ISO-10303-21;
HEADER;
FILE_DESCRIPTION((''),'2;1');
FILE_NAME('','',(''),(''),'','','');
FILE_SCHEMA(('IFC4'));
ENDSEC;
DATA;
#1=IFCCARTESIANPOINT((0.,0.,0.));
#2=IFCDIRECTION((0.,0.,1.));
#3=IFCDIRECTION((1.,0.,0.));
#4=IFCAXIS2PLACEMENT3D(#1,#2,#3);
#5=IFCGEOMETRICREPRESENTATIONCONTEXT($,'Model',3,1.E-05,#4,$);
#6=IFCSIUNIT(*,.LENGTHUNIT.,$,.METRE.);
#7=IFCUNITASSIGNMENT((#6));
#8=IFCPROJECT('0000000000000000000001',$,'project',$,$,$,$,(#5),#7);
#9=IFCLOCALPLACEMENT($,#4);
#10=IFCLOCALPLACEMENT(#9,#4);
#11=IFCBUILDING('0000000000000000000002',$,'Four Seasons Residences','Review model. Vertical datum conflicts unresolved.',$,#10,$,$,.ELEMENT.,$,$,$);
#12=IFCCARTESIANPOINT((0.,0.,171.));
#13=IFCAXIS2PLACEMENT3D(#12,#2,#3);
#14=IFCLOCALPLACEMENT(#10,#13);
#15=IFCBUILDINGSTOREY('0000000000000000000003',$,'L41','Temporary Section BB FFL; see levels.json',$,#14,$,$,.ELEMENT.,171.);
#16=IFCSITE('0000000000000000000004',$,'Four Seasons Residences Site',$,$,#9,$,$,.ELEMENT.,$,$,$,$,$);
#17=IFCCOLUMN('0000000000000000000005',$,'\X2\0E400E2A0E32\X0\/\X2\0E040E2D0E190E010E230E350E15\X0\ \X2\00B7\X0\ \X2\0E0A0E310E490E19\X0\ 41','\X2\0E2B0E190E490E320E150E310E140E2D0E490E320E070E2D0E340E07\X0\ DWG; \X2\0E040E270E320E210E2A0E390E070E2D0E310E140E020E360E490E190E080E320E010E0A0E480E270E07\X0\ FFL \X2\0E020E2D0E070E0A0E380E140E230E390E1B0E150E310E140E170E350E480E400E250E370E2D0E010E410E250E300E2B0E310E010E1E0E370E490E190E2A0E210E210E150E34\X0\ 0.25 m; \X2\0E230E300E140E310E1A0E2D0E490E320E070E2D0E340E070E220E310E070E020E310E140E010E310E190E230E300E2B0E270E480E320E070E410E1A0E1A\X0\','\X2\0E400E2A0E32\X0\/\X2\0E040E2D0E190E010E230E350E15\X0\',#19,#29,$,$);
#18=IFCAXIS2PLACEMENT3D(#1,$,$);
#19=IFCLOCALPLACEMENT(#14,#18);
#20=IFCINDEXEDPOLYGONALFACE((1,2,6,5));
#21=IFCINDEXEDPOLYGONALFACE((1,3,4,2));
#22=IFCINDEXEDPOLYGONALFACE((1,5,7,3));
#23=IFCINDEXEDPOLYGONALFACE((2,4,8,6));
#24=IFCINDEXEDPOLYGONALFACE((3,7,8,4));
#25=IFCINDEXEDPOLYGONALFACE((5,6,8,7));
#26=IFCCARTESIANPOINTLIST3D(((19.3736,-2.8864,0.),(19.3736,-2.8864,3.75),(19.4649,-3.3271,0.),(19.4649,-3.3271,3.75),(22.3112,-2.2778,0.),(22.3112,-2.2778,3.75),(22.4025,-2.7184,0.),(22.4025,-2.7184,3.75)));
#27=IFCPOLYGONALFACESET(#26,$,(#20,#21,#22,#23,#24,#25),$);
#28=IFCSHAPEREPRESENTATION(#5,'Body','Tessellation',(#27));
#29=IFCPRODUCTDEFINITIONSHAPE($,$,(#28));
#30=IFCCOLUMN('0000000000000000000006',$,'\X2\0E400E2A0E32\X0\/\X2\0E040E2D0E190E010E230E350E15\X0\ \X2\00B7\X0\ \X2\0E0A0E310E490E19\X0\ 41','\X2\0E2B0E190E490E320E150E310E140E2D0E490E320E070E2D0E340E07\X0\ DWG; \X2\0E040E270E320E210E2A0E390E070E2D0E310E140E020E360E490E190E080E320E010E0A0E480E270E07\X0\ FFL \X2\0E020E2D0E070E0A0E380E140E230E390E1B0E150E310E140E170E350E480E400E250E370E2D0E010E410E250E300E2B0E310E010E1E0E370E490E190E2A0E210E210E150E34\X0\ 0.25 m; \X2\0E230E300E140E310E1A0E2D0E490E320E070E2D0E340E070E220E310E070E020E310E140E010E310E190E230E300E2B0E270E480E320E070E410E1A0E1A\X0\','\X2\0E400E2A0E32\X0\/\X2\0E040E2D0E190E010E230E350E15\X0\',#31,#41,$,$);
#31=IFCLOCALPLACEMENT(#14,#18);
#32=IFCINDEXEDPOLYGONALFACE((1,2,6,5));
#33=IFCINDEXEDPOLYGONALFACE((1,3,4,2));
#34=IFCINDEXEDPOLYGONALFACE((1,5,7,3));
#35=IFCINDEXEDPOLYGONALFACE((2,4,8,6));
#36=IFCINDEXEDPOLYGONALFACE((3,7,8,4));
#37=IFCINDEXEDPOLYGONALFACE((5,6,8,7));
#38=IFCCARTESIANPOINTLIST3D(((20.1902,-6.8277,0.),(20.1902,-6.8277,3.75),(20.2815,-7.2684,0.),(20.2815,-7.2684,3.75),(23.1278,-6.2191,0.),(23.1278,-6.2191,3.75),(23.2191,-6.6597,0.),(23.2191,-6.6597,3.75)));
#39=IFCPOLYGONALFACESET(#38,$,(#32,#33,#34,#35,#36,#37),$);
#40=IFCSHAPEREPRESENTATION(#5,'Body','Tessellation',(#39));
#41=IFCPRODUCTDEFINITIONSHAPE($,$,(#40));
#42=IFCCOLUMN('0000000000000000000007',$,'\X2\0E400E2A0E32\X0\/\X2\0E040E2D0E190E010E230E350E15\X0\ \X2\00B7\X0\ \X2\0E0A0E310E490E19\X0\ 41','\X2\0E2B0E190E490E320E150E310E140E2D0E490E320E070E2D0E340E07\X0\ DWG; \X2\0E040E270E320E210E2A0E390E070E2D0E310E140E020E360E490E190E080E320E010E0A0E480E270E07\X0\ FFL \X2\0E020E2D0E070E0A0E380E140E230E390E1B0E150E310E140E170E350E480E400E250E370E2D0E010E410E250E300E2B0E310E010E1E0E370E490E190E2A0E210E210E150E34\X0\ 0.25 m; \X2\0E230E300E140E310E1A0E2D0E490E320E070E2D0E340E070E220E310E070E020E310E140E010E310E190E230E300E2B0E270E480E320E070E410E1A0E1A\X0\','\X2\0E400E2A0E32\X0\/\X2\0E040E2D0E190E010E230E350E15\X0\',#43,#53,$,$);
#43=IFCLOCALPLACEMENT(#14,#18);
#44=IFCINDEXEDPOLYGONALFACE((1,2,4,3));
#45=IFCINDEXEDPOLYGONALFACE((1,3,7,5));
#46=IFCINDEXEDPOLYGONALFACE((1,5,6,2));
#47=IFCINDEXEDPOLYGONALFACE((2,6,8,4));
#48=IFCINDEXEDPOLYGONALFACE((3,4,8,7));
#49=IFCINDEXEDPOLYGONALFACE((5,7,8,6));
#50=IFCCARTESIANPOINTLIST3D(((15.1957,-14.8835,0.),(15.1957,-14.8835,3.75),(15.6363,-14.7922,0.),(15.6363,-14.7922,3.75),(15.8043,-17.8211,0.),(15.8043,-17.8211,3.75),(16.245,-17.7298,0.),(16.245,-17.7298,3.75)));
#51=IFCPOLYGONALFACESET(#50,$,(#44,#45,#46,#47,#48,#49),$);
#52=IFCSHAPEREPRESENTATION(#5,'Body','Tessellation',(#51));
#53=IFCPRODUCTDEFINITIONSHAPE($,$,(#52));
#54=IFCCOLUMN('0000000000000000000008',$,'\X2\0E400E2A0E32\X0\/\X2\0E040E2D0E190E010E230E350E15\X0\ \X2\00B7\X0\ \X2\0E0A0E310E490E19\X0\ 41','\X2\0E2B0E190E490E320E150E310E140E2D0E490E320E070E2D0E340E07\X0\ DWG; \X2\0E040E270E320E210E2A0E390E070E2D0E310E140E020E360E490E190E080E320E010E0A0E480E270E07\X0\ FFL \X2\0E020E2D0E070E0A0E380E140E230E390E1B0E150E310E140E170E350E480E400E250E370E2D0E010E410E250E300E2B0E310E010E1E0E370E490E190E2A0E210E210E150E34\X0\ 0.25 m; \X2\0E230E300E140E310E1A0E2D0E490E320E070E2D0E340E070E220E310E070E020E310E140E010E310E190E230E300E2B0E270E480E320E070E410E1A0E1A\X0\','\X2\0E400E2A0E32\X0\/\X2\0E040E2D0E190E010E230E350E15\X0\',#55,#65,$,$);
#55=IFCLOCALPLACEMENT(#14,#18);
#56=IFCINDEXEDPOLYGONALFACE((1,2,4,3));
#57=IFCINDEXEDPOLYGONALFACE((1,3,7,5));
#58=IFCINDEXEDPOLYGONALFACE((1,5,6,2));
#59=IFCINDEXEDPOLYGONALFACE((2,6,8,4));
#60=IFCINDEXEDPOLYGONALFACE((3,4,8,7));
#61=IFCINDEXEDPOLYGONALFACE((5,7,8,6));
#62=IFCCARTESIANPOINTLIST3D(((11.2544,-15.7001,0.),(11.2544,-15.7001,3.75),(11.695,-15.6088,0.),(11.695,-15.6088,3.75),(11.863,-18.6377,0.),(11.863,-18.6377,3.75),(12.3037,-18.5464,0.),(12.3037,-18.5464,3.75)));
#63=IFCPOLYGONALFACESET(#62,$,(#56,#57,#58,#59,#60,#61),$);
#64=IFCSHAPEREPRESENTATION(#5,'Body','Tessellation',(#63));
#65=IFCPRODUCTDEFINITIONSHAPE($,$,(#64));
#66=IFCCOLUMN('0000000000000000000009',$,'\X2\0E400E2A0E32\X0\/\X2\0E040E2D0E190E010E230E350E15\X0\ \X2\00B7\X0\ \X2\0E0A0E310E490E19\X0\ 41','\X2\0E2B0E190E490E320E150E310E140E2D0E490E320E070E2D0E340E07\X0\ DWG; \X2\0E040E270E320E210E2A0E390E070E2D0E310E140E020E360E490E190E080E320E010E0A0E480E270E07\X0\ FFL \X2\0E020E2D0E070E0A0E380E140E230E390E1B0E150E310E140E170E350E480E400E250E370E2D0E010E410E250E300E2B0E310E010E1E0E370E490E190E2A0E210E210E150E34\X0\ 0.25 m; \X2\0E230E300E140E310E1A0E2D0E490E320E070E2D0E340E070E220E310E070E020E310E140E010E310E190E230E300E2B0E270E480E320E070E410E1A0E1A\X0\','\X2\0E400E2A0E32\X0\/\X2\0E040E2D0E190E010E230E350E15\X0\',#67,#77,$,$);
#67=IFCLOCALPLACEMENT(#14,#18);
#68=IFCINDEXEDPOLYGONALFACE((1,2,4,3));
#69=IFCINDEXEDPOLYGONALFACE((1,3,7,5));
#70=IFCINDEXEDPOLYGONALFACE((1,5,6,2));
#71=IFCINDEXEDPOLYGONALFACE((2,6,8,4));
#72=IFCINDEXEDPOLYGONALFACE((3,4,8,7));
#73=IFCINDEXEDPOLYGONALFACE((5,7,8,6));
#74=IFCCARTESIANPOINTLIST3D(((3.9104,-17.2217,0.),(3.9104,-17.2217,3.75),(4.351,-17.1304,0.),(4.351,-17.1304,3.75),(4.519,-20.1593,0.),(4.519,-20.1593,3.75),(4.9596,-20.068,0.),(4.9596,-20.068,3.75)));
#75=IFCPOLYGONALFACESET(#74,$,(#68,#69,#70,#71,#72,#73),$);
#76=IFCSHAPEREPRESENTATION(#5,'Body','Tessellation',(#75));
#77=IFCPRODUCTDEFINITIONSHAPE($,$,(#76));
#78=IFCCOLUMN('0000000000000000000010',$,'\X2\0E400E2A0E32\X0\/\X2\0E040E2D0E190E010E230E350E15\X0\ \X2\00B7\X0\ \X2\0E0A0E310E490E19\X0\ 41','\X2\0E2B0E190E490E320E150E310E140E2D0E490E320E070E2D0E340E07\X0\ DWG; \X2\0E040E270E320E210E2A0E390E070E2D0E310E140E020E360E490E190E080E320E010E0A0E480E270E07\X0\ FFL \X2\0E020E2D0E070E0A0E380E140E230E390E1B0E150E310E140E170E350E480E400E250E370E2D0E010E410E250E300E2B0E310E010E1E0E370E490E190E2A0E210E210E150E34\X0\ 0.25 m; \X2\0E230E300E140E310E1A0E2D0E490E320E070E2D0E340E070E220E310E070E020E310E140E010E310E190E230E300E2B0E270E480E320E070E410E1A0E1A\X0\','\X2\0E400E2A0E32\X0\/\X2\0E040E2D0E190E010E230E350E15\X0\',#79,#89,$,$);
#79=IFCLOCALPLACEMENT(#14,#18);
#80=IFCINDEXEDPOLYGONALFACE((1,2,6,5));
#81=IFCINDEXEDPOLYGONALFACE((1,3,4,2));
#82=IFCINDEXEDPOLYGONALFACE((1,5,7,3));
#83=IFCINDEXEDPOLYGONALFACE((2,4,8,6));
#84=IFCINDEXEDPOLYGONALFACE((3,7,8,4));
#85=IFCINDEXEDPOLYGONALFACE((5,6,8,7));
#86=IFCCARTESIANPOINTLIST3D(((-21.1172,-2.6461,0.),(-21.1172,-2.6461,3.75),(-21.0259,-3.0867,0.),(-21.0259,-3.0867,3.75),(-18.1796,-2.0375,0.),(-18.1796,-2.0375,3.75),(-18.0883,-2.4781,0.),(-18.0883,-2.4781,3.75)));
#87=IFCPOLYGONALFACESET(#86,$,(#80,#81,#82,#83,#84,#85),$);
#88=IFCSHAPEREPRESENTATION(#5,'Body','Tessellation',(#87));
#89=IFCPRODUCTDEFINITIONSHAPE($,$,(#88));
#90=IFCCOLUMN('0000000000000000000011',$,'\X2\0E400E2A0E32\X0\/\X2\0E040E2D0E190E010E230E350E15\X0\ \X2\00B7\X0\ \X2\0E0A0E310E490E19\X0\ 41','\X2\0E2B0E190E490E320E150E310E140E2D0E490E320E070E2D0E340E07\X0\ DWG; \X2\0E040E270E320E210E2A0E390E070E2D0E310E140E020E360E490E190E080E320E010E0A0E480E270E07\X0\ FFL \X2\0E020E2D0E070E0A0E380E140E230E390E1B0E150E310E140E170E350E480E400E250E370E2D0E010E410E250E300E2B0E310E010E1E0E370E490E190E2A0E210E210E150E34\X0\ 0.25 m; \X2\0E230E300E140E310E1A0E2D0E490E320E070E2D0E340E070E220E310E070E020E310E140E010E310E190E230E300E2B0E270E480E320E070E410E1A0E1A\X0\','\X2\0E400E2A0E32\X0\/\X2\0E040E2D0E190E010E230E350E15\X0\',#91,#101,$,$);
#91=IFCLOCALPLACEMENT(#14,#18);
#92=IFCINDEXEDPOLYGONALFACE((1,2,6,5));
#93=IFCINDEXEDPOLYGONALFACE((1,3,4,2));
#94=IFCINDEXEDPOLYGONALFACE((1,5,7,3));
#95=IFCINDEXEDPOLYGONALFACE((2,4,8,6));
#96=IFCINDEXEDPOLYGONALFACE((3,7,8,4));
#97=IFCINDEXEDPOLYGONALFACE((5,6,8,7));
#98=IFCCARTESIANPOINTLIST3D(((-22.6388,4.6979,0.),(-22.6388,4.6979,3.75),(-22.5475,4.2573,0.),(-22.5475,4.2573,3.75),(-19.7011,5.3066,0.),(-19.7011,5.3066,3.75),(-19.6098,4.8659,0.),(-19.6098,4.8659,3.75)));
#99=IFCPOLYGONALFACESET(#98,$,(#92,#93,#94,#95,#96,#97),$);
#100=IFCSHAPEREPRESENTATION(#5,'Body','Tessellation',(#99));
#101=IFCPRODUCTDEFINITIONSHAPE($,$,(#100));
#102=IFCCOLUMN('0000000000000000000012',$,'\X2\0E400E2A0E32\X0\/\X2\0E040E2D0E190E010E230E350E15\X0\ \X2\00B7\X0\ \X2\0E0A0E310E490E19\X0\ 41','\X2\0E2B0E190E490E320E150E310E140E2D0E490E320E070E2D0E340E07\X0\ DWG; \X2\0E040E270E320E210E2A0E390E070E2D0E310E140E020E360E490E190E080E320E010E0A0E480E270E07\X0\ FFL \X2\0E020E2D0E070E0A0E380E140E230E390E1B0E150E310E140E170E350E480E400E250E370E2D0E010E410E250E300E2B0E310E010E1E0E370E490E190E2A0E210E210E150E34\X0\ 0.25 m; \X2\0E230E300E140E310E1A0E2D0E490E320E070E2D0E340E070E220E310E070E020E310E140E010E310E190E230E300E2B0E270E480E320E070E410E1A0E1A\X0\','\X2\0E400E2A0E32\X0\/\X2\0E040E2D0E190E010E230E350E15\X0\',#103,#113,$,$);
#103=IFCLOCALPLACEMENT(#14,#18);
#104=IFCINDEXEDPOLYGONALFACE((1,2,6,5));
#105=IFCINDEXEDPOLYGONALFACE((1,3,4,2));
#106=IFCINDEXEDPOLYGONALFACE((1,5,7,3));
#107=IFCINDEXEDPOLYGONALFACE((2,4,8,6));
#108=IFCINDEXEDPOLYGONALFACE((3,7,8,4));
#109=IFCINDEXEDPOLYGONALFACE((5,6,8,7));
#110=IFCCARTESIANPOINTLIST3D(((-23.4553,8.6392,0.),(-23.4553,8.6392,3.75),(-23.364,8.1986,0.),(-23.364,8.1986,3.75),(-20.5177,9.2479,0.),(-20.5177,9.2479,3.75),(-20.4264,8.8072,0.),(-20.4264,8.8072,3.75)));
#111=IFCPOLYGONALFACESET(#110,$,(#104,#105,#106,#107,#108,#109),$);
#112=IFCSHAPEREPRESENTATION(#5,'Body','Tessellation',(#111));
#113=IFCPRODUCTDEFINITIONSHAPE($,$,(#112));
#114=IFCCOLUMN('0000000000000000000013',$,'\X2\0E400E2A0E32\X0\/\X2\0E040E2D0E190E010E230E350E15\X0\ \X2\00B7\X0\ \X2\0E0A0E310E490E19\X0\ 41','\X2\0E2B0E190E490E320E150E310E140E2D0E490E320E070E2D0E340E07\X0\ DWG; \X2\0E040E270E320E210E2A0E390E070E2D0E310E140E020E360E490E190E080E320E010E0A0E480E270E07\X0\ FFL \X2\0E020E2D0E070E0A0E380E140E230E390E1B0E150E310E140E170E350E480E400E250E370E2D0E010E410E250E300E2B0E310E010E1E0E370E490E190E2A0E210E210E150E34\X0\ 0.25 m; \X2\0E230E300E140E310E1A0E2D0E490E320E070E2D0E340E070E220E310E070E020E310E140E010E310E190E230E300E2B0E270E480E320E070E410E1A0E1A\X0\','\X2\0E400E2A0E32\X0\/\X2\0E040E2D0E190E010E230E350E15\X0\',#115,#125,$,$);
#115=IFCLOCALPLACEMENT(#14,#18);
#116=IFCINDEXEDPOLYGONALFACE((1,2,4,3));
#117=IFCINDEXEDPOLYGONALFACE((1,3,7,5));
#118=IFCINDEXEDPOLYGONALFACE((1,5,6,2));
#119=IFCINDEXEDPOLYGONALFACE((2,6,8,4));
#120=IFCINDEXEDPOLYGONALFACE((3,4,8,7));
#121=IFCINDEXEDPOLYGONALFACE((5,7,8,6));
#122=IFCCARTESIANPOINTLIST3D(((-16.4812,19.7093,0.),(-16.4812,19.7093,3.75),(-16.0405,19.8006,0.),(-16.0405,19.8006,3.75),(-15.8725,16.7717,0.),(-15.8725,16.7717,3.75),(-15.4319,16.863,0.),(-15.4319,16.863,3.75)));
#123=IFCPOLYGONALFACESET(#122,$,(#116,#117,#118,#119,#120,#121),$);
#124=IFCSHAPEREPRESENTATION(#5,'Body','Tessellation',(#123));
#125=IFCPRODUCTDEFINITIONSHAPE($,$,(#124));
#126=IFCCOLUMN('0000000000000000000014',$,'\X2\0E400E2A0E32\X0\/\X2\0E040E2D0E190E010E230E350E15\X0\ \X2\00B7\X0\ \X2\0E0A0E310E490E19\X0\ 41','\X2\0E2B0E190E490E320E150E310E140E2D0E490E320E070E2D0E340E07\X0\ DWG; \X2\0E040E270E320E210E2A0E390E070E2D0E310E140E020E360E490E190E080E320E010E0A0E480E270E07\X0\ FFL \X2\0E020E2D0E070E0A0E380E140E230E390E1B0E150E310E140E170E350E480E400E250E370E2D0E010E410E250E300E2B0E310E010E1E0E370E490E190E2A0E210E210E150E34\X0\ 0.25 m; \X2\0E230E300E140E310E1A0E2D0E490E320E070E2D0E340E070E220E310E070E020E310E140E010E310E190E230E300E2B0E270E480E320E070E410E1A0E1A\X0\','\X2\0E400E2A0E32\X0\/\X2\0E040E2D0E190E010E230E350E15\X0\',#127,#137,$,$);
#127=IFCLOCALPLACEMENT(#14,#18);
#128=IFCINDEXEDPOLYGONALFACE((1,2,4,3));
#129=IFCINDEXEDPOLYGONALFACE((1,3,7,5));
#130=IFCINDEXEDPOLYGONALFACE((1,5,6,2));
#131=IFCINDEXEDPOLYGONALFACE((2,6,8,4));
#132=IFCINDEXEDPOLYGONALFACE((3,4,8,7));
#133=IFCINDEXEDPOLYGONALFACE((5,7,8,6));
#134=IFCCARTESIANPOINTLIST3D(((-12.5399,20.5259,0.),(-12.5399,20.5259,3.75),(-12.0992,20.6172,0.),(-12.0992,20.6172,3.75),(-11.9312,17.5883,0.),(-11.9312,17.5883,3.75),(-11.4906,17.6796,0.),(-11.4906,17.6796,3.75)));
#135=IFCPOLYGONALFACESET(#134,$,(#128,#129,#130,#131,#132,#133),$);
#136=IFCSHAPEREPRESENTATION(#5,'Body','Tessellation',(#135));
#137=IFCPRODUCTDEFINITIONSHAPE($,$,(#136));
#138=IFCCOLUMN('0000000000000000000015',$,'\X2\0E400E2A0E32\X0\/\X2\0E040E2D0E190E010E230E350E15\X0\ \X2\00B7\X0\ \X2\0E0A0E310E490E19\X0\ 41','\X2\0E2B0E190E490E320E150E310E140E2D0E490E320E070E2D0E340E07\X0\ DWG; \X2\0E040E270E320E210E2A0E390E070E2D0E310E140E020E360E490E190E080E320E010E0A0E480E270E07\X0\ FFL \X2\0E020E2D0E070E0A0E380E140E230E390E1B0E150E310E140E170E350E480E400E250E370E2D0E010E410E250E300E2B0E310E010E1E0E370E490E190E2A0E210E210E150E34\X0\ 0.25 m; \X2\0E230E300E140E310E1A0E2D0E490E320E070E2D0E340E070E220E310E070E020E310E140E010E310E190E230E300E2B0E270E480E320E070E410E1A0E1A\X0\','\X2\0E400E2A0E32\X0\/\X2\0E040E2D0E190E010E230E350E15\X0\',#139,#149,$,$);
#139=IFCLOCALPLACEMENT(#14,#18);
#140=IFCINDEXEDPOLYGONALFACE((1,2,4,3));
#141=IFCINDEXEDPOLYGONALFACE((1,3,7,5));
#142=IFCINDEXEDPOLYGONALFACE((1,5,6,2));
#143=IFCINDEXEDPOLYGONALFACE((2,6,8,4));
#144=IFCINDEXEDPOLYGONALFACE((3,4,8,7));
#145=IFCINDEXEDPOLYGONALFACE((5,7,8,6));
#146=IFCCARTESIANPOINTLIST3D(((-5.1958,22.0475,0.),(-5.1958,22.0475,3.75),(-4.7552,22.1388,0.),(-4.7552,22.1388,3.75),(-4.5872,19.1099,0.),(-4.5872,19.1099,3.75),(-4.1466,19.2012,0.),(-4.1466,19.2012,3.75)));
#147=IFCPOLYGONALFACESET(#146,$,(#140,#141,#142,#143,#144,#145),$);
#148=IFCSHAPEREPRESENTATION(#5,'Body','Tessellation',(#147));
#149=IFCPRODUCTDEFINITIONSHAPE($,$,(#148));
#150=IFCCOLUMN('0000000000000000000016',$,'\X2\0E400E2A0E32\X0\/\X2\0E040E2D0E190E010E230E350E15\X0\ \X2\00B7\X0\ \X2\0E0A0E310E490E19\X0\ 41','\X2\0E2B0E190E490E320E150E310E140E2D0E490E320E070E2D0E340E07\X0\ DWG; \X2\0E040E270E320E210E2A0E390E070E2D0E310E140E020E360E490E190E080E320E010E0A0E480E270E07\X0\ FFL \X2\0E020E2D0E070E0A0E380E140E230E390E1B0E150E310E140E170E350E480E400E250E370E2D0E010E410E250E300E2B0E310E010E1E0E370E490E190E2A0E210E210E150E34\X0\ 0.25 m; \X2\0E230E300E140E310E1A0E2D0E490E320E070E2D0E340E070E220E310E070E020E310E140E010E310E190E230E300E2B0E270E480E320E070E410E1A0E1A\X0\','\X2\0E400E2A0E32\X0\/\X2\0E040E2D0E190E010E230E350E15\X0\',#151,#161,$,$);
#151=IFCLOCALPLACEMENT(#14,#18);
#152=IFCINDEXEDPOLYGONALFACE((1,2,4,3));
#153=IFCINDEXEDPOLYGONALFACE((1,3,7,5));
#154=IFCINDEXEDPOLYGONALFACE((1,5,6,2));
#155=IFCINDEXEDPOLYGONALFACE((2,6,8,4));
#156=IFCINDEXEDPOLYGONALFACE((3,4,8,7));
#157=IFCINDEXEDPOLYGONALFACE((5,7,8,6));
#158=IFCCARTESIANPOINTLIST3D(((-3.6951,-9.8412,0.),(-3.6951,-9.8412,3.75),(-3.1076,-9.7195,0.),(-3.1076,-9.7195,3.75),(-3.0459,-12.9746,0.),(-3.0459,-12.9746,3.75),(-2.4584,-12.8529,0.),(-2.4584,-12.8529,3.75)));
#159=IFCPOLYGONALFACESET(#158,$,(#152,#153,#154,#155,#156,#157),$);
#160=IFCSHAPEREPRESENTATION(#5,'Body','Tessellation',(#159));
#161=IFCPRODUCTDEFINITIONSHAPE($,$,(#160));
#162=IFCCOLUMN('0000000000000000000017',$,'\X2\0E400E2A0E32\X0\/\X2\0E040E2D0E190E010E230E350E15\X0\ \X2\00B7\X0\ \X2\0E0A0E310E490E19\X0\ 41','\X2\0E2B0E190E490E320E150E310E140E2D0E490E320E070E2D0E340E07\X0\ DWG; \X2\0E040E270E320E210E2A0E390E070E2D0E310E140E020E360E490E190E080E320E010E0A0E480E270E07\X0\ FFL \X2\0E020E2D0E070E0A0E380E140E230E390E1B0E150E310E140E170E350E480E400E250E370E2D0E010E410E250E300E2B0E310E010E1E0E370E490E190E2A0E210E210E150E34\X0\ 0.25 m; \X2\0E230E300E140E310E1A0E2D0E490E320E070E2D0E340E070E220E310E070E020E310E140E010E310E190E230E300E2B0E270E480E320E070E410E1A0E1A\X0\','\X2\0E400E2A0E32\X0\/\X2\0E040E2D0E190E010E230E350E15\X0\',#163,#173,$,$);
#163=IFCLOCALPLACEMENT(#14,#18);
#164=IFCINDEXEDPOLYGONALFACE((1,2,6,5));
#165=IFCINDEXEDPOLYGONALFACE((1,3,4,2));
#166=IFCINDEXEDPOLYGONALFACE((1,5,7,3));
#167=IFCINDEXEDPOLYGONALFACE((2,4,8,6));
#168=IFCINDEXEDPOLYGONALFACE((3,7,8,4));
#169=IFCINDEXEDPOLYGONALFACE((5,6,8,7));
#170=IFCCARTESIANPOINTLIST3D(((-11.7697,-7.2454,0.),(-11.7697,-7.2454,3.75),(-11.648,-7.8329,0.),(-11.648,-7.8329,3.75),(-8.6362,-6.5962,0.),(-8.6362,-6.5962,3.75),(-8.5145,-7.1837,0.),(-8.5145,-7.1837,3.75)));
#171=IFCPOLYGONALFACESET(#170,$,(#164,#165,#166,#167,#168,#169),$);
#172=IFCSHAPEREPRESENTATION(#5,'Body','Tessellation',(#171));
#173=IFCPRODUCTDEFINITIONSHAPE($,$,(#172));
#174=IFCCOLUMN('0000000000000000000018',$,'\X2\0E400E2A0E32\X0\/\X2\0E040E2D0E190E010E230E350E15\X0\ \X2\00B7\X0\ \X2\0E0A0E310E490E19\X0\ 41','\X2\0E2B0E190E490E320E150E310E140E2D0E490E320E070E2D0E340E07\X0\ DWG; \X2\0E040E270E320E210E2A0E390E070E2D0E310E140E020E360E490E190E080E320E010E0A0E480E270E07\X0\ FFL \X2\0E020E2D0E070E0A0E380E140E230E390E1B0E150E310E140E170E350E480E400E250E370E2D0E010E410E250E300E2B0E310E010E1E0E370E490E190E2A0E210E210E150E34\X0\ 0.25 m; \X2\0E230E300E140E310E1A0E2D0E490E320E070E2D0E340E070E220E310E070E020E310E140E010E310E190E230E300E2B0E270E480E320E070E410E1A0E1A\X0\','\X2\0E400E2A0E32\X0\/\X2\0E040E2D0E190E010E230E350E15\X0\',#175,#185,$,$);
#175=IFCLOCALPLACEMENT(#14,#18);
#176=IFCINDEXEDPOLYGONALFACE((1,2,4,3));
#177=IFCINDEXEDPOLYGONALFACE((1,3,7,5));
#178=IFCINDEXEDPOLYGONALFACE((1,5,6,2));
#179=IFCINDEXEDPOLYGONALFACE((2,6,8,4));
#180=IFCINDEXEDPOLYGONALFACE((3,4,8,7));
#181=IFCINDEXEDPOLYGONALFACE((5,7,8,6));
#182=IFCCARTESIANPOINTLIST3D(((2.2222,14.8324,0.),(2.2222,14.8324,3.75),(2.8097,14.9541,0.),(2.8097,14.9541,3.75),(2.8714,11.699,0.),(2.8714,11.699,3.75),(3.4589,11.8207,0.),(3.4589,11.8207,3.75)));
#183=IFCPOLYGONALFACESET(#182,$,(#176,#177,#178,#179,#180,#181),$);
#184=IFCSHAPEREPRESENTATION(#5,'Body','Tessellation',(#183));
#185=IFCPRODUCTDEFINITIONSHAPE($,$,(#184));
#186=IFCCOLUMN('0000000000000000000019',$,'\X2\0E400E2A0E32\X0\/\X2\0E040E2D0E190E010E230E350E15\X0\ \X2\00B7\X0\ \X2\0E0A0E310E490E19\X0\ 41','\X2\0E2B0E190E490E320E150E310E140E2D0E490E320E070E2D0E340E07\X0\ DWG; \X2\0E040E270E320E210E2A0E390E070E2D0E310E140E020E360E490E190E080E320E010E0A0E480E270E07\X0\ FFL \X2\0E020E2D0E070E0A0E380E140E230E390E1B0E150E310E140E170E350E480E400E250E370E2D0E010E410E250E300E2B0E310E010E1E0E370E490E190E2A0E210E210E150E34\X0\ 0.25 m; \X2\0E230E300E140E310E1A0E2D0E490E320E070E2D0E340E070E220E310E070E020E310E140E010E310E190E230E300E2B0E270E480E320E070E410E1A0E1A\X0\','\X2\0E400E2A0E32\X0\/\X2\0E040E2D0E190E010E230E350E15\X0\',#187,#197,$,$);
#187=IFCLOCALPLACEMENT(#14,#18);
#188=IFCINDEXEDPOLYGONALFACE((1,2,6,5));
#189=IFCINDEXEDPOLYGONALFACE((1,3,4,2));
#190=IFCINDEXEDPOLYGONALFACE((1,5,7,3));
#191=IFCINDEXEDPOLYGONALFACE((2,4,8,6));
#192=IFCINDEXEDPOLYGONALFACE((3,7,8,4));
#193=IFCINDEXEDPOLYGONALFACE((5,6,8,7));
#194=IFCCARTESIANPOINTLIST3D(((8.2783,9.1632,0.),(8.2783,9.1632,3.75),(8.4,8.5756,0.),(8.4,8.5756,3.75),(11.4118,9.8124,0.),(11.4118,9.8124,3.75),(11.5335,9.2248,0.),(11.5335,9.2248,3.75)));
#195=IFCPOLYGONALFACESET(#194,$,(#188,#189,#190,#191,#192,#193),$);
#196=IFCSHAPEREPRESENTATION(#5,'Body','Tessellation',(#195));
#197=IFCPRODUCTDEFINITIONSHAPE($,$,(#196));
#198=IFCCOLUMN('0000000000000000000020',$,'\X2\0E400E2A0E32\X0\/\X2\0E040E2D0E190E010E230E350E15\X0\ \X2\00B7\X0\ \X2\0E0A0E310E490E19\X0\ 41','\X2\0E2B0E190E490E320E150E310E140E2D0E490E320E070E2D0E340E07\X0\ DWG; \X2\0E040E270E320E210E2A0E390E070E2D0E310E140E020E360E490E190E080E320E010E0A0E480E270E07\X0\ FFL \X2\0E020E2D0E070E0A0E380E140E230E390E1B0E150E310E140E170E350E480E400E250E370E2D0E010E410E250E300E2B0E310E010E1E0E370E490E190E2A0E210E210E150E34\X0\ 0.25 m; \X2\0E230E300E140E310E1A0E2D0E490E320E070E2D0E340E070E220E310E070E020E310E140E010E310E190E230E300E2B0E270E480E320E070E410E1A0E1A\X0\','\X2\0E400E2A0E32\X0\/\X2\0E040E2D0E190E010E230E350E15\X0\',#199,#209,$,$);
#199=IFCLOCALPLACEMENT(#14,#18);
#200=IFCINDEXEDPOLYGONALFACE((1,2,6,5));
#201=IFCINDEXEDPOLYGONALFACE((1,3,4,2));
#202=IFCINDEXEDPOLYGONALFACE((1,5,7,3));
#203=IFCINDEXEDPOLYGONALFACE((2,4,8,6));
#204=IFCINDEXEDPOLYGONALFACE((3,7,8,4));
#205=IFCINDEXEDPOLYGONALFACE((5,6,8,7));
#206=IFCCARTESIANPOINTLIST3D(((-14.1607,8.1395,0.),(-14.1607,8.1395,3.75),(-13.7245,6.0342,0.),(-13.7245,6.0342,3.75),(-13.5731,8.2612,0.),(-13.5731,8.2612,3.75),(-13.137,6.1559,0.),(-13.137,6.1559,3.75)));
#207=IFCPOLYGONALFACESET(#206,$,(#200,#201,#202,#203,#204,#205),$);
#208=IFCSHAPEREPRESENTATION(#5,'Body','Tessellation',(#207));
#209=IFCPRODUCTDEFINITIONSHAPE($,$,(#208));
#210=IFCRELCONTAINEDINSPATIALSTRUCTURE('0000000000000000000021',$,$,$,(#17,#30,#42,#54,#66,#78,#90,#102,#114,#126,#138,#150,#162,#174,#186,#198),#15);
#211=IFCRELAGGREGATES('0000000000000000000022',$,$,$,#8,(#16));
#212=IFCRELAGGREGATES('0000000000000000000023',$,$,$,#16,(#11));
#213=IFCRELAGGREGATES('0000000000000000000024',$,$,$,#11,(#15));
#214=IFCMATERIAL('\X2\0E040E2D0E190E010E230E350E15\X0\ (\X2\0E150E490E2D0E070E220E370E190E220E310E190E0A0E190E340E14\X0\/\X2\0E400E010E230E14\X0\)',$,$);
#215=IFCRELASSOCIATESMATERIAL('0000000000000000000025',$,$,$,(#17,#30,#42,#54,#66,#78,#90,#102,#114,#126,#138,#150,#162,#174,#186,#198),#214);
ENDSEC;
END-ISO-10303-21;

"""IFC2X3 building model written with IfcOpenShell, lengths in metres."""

from ifc_helpers import new_model, si_unit, frame, origin_with_axes, place, context, project, spatial, polyline, outline, extrude, material, element, save


model = new_model("IFC2X3")

# Units and contexts
model_context = context("Model", 3, precision=1e-05, world=origin_with_axes())
ifc_project = project(units=[si_unit("LENGTHUNIT", "METRE")], contexts=[model_context])

# Site, building, storey
site_placement = place(None, origin_with_axes())
site = spatial("IfcSite", under=ifc_project, at=site_placement, Name="Four Seasons Residences Site", CompositionType="ELEMENT")
building_placement = place(site_placement, origin_with_axes())
building = spatial("IfcBuilding", under=site, at=building_placement, Name="Four Seasons Residences", Description="Review model. Vertical datum conflicts unresolved.", CompositionType="ELEMENT")
storey_placement = place(building_placement, frame((0.0, 0.0, 171.0), z_axis=(0.0, 0.0, 1.0), x_axis=(1.0, 0.0, 0.0)))
storey = spatial("IfcBuildingStorey", under=building, at=storey_placement, Name="L41", Description="Temporary Section BB FFL; see levels.json", CompositionType="ELEMENT", Elevation=171.0)

# Columns
ifc_material = material(Name="คอนกรีต (ต้องยืนยันชนิด/เกรด)")
column_1_placement = place(storey_placement, origin_with_axes())
element("IfcColumn", 1, at=column_1_placement, inside=storey, material=ifc_material, Name="เสา/คอนกรีต · ชั้น 41", Description="หน้าตัดอ้างอิง DWG; ความสูงอัดขึ้นจากช่วง FFL ของชุดรูปตัดที่เลือกและหักพื้นสมมติ 0.25 m; ระดับอ้างอิงยังขัดกันระหว่างแบบ", ObjectType="เสา/คอนกรีต", context=model_context, shape_type="SweptSolid", body=[
    extrude(outline(polyline([(22.3112, -2.2778), (22.4025, -2.7184), (19.4649, -3.3271), (19.3736, -2.8864), (22.3112, -2.2778)])), origin_with_axes(), (0.0, 0.0, 1.0), 3.75),
])
column_2_placement = place(storey_placement, origin_with_axes())
element("IfcColumn", 2, at=column_2_placement, inside=storey, material=ifc_material, Name="เสา/คอนกรีต · ชั้น 41", Description="หน้าตัดอ้างอิง DWG; ความสูงอัดขึ้นจากช่วง FFL ของชุดรูปตัดที่เลือกและหักพื้นสมมติ 0.25 m; ระดับอ้างอิงยังขัดกันระหว่างแบบ", ObjectType="เสา/คอนกรีต", context=model_context, shape_type="SweptSolid", body=[
    extrude(outline(polyline([(23.1278, -6.2191), (23.2191, -6.6597), (20.2815, -7.2684), (20.1902, -6.8277), (23.1278, -6.2191)])), origin_with_axes(), (0.0, 0.0, 1.0), 3.75),
])
column_3_placement = place(storey_placement, origin_with_axes())
element("IfcColumn", 3, at=column_3_placement, inside=storey, material=ifc_material, Name="เสา/คอนกรีต · ชั้น 41", Description="หน้าตัดอ้างอิง DWG; ความสูงอัดขึ้นจากช่วง FFL ของชุดรูปตัดที่เลือกและหักพื้นสมมติ 0.25 m; ระดับอ้างอิงยังขัดกันระหว่างแบบ", ObjectType="เสา/คอนกรีต", context=model_context, shape_type="SweptSolid", body=[
    extrude(outline(polyline([(15.6363, -14.7922), (16.245, -17.7298), (15.8043, -17.8211), (15.1957, -14.8835), (15.6363, -14.7922)])), origin_with_axes(), (0.0, 0.0, 1.0), 3.75),
])
column_4_placement = place(storey_placement, origin_with_axes())
element("IfcColumn", 4, at=column_4_placement, inside=storey, material=ifc_material, Name="เสา/คอนกรีต · ชั้น 41", Description="หน้าตัดอ้างอิง DWG; ความสูงอัดขึ้นจากช่วง FFL ของชุดรูปตัดที่เลือกและหักพื้นสมมติ 0.25 m; ระดับอ้างอิงยังขัดกันระหว่างแบบ", ObjectType="เสา/คอนกรีต", context=model_context, shape_type="SweptSolid", body=[
    extrude(outline(polyline([(11.695, -15.6088), (12.3037, -18.5464), (11.863, -18.6377), (11.2544, -15.7001), (11.695, -15.6088)])), origin_with_axes(), (0.0, 0.0, 1.0), 3.75),
])
column_5_placement = place(storey_placement, origin_with_axes())
element("IfcColumn", 5, at=column_5_placement, inside=storey, material=ifc_material, Name="เสา/คอนกรีต · ชั้น 41", Description="หน้าตัดอ้างอิง DWG; ความสูงอัดขึ้นจากช่วง FFL ของชุดรูปตัดที่เลือกและหักพื้นสมมติ 0.25 m; ระดับอ้างอิงยังขัดกันระหว่างแบบ", ObjectType="เสา/คอนกรีต", context=model_context, shape_type="SweptSolid", body=[
    extrude(outline(polyline([(4.351, -17.1304), (4.9596, -20.068), (4.519, -20.1593), (3.9104, -17.2217), (4.351, -17.1304)])), origin_with_axes(), (0.0, 0.0, 1.0), 3.75),
])
column_6_placement = place(storey_placement, origin_with_axes())
element("IfcColumn", 6, at=column_6_placement, inside=storey, material=ifc_material, Name="เสา/คอนกรีต · ชั้น 41", Description="หน้าตัดอ้างอิง DWG; ความสูงอัดขึ้นจากช่วง FFL ของชุดรูปตัดที่เลือกและหักพื้นสมมติ 0.25 m; ระดับอ้างอิงยังขัดกันระหว่างแบบ", ObjectType="เสา/คอนกรีต", context=model_context, shape_type="SweptSolid", body=[
    extrude(outline(polyline([(-21.0259, -3.0867), (-21.1172, -2.6461), (-18.1796, -2.0375), (-18.0883, -2.4781), (-21.0259, -3.0867)])), origin_with_axes(), (0.0, 0.0, 1.0), 3.75),
])
column_7_placement = place(storey_placement, origin_with_axes())
element("IfcColumn", 7, at=column_7_placement, inside=storey, material=ifc_material, Name="เสา/คอนกรีต · ชั้น 41", Description="หน้าตัดอ้างอิง DWG; ความสูงอัดขึ้นจากช่วง FFL ของชุดรูปตัดที่เลือกและหักพื้นสมมติ 0.25 m; ระดับอ้างอิงยังขัดกันระหว่างแบบ", ObjectType="เสา/คอนกรีต", context=model_context, shape_type="SweptSolid", body=[
    extrude(outline(polyline([(-22.5475, 4.2573), (-22.6388, 4.6979), (-19.7011, 5.3066), (-19.6098, 4.8659), (-22.5475, 4.2573)])), origin_with_axes(), (0.0, 0.0, 1.0), 3.75),
])
column_8_placement = place(storey_placement, origin_with_axes())
element("IfcColumn", 8, at=column_8_placement, inside=storey, material=ifc_material, Name="เสา/คอนกรีต · ชั้น 41", Description="หน้าตัดอ้างอิง DWG; ความสูงอัดขึ้นจากช่วง FFL ของชุดรูปตัดที่เลือกและหักพื้นสมมติ 0.25 m; ระดับอ้างอิงยังขัดกันระหว่างแบบ", ObjectType="เสา/คอนกรีต", context=model_context, shape_type="SweptSolid", body=[
    extrude(outline(polyline([(-23.364, 8.1986), (-23.4553, 8.6392), (-20.5177, 9.2479), (-20.4264, 8.8072), (-23.364, 8.1986)])), origin_with_axes(), (0.0, 0.0, 1.0), 3.75),
])
column_9_placement = place(storey_placement, origin_with_axes())
element("IfcColumn", 9, at=column_9_placement, inside=storey, material=ifc_material, Name="เสา/คอนกรีต · ชั้น 41", Description="หน้าตัดอ้างอิง DWG; ความสูงอัดขึ้นจากช่วง FFL ของชุดรูปตัดที่เลือกและหักพื้นสมมติ 0.25 m; ระดับอ้างอิงยังขัดกันระหว่างแบบ", ObjectType="เสา/คอนกรีต", context=model_context, shape_type="SweptSolid", body=[
    extrude(outline(polyline([(-15.8725, 16.7717), (-16.4812, 19.7093), (-16.0405, 19.8006), (-15.4319, 16.863), (-15.8725, 16.7717)])), origin_with_axes(), (0.0, 0.0, 1.0), 3.75),
])
column_10_placement = place(storey_placement, origin_with_axes())
element("IfcColumn", 10, at=column_10_placement, inside=storey, material=ifc_material, Name="เสา/คอนกรีต · ชั้น 41", Description="หน้าตัดอ้างอิง DWG; ความสูงอัดขึ้นจากช่วง FFL ของชุดรูปตัดที่เลือกและหักพื้นสมมติ 0.25 m; ระดับอ้างอิงยังขัดกันระหว่างแบบ", ObjectType="เสา/คอนกรีต", context=model_context, shape_type="SweptSolid", body=[
    extrude(outline(polyline([(-11.9312, 17.5883), (-12.5399, 20.5259), (-12.0992, 20.6172), (-11.4906, 17.6796), (-11.9312, 17.5883)])), origin_with_axes(), (0.0, 0.0, 1.0), 3.75),
])
column_11_placement = place(storey_placement, origin_with_axes())
element("IfcColumn", 11, at=column_11_placement, inside=storey, material=ifc_material, Name="เสา/คอนกรีต · ชั้น 41", Description="หน้าตัดอ้างอิง DWG; ความสูงอัดขึ้นจากช่วง FFL ของชุดรูปตัดที่เลือกและหักพื้นสมมติ 0.25 m; ระดับอ้างอิงยังขัดกันระหว่างแบบ", ObjectType="เสา/คอนกรีต", context=model_context, shape_type="SweptSolid", body=[
    extrude(outline(polyline([(-4.5872, 19.1099), (-5.1958, 22.0475), (-4.7552, 22.1388), (-4.1466, 19.2012), (-4.5872, 19.1099)])), origin_with_axes(), (0.0, 0.0, 1.0), 3.75),
])
column_12_placement = place(storey_placement, origin_with_axes())
element("IfcColumn", 12, at=column_12_placement, inside=storey, material=ifc_material, Name="เสา/คอนกรีต · ชั้น 41", Description="หน้าตัดอ้างอิง DWG; ความสูงอัดขึ้นจากช่วง FFL ของชุดรูปตัดที่เลือกและหักพื้นสมมติ 0.25 m; ระดับอ้างอิงยังขัดกันระหว่างแบบ", ObjectType="เสา/คอนกรีต", context=model_context, shape_type="SweptSolid", body=[
    extrude(outline(polyline([(-3.1076, -9.7195), (-2.4584, -12.8529), (-3.0459, -12.9746), (-3.6951, -9.8412), (-3.1076, -9.7195)])), origin_with_axes(), (0.0, 0.0, 1.0), 3.75),
])
column_13_placement = place(storey_placement, origin_with_axes())
element("IfcColumn", 13, at=column_13_placement, inside=storey, material=ifc_material, Name="เสา/คอนกรีต · ชั้น 41", Description="หน้าตัดอ้างอิง DWG; ความสูงอัดขึ้นจากช่วง FFL ของชุดรูปตัดที่เลือกและหักพื้นสมมติ 0.25 m; ระดับอ้างอิงยังขัดกันระหว่างแบบ", ObjectType="เสา/คอนกรีต", context=model_context, shape_type="SweptSolid", body=[
    extrude(outline(polyline([(-8.5145, -7.1837), (-11.648, -7.8329), (-11.7697, -7.2454), (-8.6362, -6.5962), (-8.5145, -7.1837)])), origin_with_axes(), (0.0, 0.0, 1.0), 3.75),
])
column_14_placement = place(storey_placement, origin_with_axes())
element("IfcColumn", 14, at=column_14_placement, inside=storey, material=ifc_material, Name="เสา/คอนกรีต · ชั้น 41", Description="หน้าตัดอ้างอิง DWG; ความสูงอัดขึ้นจากช่วง FFL ของชุดรูปตัดที่เลือกและหักพื้นสมมติ 0.25 m; ระดับอ้างอิงยังขัดกันระหว่างแบบ", ObjectType="เสา/คอนกรีต", context=model_context, shape_type="SweptSolid", body=[
    extrude(outline(polyline([(2.8097, 14.9541), (3.4589, 11.8207), (2.8714, 11.699), (2.2222, 14.8324), (2.8097, 14.9541)])), origin_with_axes(), (0.0, 0.0, 1.0), 3.75),
])
column_15_placement = place(storey_placement, origin_with_axes())
element("IfcColumn", 15, at=column_15_placement, inside=storey, material=ifc_material, Name="เสา/คอนกรีต · ชั้น 41", Description="หน้าตัดอ้างอิง DWG; ความสูงอัดขึ้นจากช่วง FFL ของชุดรูปตัดที่เลือกและหักพื้นสมมติ 0.25 m; ระดับอ้างอิงยังขัดกันระหว่างแบบ", ObjectType="เสา/คอนกรีต", context=model_context, shape_type="SweptSolid", body=[
    extrude(outline(polyline([(11.5335, 9.2248), (8.4, 8.5756), (8.2783, 9.1632), (11.4118, 9.8124), (11.5335, 9.2248)])), origin_with_axes(), (0.0, 0.0, 1.0), 3.75),
])
column_16_placement = place(storey_placement, origin_with_axes())
element("IfcColumn", 16, at=column_16_placement, inside=storey, material=ifc_material, Name="เสา/คอนกรีต · ชั้น 41", Description="หน้าตัดอ้างอิง DWG; ความสูงอัดขึ้นจากช่วง FFL ของชุดรูปตัดที่เลือกและหักพื้นสมมติ 0.25 m; ระดับอ้างอิงยังขัดกันระหว่างแบบ", ObjectType="เสา/คอนกรีต", context=model_context, shape_type="SweptSolid", body=[
    extrude(outline(polyline([(-13.5731, 8.2612), (-13.137, 6.1559), (-13.7245, 6.0342), (-14.1607, 8.1395), (-13.5731, 8.2612)])), origin_with_axes(), (0.0, 0.0, 1.0), 3.75),
])

save(model, "model.ifc")
